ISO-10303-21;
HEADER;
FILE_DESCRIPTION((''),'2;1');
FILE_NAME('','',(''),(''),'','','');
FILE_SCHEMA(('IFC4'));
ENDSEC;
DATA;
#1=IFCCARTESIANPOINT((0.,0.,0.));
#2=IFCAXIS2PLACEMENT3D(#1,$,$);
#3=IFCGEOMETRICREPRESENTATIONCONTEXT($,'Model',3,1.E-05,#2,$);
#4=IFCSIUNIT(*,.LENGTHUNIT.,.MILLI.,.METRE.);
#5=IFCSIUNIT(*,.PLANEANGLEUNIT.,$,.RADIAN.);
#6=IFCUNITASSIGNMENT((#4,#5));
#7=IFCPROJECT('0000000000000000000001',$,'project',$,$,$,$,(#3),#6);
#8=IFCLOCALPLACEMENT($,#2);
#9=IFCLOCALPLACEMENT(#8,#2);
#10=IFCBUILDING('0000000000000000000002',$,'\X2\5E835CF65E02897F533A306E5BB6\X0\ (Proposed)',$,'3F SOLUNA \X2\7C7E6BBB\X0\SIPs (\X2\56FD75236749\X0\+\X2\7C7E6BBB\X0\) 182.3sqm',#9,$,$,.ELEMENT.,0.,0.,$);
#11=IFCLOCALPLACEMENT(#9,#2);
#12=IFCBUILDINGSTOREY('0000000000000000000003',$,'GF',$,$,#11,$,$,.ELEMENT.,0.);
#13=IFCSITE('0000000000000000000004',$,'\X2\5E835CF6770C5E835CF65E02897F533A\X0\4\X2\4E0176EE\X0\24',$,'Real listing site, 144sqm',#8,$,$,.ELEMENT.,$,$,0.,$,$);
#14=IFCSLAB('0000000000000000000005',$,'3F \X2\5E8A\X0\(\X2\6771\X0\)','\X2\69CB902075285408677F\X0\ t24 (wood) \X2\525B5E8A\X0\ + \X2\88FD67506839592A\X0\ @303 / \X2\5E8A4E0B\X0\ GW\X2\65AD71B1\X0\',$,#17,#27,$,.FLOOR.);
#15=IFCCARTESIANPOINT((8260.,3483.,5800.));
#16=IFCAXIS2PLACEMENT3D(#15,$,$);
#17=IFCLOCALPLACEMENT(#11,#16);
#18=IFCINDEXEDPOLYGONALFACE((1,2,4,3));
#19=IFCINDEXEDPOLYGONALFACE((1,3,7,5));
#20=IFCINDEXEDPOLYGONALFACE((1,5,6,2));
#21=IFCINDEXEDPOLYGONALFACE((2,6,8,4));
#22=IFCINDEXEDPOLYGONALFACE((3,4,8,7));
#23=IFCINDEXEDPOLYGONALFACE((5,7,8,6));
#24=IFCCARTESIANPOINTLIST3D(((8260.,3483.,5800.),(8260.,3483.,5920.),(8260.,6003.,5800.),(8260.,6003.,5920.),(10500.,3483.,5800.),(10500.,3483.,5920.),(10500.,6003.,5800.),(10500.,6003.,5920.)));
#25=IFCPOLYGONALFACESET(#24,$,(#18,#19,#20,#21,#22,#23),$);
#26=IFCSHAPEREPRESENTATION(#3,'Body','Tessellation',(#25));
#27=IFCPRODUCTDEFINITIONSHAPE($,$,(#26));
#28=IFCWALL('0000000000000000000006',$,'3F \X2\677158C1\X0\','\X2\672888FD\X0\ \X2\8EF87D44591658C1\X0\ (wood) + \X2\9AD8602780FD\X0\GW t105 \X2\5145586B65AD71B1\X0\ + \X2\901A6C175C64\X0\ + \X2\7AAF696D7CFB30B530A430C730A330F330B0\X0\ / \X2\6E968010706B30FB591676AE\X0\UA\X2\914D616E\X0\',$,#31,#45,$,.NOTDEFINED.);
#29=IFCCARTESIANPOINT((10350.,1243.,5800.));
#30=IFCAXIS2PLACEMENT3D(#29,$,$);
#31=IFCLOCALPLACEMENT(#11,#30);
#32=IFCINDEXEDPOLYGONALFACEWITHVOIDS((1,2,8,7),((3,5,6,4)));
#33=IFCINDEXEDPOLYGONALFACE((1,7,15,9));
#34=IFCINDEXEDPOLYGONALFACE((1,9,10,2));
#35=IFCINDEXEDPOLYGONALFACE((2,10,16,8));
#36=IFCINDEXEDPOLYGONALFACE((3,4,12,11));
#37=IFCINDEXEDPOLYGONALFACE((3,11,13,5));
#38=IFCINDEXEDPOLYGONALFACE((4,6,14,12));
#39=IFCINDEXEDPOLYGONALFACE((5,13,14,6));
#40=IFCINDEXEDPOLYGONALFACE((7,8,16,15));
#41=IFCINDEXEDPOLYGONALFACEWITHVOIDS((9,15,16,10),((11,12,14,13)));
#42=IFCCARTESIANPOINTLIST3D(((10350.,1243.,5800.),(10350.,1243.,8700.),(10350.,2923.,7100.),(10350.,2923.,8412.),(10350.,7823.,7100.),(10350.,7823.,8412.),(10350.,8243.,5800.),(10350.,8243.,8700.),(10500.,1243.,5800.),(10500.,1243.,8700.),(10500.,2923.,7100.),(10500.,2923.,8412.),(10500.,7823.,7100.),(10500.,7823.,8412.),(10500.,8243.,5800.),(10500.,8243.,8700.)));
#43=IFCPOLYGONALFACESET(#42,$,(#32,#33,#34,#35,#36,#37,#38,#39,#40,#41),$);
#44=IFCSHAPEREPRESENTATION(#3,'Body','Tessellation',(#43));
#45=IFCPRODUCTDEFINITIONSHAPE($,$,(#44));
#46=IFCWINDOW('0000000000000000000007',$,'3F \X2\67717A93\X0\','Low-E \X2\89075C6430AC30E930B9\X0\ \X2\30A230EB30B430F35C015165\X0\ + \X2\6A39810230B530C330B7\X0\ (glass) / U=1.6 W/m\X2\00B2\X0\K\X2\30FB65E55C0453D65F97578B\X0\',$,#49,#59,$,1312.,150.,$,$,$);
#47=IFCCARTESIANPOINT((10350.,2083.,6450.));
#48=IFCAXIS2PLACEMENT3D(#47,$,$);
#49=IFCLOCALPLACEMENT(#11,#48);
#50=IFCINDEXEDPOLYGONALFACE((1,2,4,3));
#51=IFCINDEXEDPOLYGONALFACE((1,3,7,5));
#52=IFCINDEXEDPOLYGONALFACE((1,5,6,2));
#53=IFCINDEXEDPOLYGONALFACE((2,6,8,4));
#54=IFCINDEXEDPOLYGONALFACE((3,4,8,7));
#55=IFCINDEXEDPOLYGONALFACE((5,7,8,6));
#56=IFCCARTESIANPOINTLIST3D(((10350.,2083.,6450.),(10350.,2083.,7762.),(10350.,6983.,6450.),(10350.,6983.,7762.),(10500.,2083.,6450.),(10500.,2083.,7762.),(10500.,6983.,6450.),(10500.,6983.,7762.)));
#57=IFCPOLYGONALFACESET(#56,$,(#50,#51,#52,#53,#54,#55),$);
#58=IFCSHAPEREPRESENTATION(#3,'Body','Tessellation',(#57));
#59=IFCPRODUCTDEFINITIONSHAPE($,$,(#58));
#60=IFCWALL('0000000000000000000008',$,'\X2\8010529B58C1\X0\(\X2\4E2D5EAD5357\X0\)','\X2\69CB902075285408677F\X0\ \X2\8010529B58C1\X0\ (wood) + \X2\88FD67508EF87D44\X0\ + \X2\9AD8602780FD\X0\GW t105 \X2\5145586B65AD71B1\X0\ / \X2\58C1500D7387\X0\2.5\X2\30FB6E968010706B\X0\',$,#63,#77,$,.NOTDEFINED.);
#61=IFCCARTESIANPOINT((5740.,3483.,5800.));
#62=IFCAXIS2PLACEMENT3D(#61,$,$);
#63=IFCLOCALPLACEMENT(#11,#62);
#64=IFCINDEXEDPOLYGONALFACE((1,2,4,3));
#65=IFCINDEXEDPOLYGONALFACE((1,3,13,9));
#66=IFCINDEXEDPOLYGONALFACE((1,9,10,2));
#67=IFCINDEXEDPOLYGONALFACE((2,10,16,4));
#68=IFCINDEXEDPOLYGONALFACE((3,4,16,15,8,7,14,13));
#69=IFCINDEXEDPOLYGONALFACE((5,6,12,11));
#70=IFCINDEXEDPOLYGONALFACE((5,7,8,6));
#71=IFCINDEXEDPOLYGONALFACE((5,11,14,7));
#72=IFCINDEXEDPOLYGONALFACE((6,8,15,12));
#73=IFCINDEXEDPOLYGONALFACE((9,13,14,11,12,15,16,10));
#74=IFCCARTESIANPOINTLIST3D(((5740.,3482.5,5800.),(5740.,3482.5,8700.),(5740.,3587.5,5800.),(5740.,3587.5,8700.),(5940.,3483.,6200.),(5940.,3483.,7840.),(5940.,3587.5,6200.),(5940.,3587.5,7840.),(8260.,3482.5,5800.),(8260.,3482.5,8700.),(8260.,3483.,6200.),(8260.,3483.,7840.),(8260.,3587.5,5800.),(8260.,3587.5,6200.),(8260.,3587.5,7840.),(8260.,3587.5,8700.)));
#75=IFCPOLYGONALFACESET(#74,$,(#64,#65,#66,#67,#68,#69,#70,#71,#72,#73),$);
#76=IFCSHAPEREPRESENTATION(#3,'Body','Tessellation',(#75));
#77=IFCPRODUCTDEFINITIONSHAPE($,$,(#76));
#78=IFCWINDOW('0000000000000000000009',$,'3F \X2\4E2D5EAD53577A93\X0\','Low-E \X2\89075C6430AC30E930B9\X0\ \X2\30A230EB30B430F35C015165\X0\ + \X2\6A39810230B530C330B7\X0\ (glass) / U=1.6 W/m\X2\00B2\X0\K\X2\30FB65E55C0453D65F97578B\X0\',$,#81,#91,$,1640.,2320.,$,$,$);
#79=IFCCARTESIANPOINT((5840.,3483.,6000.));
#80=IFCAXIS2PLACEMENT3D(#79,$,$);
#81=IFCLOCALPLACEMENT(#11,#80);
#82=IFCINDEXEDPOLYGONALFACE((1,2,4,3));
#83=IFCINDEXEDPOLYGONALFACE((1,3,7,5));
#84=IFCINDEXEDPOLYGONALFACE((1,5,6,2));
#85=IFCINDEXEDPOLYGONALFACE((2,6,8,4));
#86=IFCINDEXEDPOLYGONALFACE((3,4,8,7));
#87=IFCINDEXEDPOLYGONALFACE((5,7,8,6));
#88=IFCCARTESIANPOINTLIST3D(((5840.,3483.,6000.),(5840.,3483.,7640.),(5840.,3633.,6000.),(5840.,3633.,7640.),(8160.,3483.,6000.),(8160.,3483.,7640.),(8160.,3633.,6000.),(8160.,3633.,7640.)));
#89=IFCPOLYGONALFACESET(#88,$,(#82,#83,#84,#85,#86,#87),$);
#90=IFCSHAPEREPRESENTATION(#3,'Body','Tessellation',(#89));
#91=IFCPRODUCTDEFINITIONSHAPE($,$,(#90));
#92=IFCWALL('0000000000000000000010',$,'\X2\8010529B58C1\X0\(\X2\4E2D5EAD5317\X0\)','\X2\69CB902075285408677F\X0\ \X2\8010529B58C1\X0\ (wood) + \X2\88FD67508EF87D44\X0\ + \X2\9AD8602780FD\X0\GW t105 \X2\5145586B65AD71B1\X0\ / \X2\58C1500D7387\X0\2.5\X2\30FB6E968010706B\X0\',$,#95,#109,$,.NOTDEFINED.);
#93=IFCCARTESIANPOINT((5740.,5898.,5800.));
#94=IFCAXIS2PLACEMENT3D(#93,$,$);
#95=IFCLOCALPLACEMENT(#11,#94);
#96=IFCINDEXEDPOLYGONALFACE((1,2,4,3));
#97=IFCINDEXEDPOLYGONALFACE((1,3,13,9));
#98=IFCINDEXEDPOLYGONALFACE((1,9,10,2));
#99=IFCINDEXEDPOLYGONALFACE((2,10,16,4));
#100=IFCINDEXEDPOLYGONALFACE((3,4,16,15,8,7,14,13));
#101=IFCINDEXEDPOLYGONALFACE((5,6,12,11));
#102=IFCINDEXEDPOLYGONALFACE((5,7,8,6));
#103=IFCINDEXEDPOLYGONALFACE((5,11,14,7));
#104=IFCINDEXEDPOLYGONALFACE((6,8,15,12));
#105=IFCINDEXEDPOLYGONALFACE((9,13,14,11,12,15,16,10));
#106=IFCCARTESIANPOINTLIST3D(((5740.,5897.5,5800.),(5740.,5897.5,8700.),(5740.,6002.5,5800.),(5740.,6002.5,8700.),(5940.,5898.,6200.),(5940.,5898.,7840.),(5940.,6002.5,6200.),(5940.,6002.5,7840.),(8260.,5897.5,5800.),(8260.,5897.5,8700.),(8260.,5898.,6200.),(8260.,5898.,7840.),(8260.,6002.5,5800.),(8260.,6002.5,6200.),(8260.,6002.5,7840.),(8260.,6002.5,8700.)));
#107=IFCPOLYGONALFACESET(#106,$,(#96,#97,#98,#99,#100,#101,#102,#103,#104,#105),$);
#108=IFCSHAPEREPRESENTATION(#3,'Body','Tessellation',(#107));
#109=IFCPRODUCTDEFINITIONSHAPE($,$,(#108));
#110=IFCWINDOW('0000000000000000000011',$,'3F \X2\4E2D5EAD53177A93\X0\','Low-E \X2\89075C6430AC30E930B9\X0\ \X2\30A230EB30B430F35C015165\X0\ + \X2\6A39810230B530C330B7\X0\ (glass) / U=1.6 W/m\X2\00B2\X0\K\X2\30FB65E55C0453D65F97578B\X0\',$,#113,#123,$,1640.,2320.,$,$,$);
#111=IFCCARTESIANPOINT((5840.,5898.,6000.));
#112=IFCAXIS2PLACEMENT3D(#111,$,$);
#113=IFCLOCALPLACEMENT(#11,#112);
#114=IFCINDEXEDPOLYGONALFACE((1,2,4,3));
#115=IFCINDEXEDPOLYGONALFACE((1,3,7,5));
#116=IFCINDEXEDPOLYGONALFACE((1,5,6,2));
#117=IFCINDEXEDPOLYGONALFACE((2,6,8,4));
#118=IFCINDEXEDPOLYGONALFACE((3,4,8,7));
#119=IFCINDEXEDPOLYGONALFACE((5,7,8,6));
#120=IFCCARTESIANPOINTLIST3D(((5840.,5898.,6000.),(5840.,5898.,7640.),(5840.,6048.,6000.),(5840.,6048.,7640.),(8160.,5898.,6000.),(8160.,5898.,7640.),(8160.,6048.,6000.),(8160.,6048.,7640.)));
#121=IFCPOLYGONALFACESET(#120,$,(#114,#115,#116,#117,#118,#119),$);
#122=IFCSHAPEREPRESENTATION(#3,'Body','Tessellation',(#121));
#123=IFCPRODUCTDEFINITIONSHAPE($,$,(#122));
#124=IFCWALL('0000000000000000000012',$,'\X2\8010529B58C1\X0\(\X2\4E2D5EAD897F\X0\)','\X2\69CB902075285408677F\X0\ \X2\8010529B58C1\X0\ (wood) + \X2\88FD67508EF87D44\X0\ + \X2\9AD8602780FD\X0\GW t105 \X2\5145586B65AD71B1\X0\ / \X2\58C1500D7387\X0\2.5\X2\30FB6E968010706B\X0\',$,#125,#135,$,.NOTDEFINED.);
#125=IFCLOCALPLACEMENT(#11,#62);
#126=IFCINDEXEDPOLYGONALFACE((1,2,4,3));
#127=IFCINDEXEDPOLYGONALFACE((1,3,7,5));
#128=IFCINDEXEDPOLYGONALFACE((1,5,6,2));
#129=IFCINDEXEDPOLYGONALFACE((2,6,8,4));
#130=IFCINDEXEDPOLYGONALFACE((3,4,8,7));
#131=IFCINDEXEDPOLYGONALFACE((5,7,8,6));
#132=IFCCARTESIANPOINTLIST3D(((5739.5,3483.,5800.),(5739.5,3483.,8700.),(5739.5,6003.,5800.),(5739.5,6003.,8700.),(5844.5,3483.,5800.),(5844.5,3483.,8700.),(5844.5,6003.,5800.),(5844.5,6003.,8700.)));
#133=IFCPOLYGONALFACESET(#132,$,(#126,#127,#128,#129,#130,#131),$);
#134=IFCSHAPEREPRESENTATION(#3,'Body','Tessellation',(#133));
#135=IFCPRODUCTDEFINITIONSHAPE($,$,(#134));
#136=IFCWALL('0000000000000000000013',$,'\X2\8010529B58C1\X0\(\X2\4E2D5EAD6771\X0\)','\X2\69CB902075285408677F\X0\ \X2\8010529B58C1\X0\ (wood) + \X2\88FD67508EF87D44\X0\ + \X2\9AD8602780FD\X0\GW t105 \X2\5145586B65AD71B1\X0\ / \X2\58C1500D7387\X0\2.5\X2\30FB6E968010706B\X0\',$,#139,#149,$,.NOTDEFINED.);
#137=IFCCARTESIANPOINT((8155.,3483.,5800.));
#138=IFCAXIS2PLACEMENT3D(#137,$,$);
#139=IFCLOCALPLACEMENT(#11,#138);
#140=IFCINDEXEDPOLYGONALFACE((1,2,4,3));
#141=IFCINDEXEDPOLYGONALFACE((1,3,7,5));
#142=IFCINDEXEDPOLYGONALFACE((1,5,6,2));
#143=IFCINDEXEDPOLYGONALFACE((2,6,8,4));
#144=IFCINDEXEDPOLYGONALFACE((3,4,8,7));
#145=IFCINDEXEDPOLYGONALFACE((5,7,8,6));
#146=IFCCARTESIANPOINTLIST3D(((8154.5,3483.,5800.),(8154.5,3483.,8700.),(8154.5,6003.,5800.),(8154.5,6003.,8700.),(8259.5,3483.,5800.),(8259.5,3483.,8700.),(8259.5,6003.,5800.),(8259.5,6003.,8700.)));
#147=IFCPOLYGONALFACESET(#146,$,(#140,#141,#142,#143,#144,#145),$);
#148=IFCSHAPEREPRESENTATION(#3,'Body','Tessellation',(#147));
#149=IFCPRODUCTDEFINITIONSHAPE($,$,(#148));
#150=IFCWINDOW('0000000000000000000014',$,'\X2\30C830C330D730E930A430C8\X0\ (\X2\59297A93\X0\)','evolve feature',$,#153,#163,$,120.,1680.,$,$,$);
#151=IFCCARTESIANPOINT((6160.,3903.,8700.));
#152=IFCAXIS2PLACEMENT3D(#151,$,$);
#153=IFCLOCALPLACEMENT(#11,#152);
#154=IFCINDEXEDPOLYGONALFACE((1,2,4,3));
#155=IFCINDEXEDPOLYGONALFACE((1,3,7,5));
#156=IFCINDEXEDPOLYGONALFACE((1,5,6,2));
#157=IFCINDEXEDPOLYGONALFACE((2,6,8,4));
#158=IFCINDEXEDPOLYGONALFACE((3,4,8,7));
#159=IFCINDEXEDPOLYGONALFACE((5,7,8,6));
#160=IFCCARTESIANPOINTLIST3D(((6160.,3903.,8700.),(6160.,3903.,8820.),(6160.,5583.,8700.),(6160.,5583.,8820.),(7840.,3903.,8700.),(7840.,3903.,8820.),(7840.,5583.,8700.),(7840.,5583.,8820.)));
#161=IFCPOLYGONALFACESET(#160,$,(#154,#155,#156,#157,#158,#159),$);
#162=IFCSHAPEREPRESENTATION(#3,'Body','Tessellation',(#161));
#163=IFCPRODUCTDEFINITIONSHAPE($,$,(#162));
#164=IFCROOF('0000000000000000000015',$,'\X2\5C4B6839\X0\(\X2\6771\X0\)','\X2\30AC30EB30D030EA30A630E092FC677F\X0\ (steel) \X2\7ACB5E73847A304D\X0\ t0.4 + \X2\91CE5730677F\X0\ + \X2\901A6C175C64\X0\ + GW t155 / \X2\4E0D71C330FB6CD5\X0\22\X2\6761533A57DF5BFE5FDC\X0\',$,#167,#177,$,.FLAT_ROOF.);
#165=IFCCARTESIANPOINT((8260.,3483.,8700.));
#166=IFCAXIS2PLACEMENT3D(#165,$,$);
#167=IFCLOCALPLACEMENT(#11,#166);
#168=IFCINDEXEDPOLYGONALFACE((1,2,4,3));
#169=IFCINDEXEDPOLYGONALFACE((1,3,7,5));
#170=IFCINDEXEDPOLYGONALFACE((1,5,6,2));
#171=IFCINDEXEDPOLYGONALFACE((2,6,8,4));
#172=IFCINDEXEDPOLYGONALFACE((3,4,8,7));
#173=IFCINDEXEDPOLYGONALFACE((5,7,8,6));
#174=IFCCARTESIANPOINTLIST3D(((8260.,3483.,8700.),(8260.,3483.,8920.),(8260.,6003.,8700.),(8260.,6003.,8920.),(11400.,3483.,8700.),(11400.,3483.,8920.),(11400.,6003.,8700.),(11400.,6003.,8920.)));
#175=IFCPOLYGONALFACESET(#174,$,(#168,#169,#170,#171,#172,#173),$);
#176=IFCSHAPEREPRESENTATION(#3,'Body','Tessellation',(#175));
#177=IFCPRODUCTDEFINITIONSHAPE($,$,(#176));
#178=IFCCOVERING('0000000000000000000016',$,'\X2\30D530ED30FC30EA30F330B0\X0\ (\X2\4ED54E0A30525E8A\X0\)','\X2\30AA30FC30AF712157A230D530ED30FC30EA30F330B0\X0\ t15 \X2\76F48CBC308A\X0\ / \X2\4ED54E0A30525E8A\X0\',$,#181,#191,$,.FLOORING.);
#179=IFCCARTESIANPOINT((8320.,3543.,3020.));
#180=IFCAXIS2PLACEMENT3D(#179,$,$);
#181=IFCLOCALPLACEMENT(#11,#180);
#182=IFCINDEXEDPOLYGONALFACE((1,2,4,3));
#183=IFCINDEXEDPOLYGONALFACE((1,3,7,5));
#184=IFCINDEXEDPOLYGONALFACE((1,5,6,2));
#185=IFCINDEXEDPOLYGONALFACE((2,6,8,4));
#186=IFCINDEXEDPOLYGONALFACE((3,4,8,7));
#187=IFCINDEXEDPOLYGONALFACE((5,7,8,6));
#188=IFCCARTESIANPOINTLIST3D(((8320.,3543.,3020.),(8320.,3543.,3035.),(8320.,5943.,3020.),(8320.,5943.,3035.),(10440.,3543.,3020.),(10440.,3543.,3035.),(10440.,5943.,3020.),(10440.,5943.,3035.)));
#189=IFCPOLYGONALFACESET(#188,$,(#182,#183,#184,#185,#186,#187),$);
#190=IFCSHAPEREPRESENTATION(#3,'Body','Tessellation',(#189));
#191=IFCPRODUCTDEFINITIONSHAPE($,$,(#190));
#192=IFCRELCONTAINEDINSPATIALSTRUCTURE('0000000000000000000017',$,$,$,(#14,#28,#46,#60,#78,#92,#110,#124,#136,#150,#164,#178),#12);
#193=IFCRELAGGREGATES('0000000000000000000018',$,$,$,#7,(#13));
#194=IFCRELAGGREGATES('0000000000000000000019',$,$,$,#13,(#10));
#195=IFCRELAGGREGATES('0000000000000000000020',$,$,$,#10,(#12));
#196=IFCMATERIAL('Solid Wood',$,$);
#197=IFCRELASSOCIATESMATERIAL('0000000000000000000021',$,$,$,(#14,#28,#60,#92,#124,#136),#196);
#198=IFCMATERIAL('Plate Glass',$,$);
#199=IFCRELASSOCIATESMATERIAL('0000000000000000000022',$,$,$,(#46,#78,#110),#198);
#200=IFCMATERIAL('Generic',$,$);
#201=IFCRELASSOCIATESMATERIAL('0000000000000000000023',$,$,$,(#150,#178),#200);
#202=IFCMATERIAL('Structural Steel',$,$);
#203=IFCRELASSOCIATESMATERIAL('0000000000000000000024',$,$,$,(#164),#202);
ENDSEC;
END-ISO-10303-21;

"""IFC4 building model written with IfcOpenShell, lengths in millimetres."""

from ifc_helpers import new_model, si_unit, frame, frame_2d, origin, place, context, project, spatial, rectangle, extrude, material, element, fill, save


model = new_model("IFC4")

# Units and contexts
model_context = context("Model", 3, precision=1e-05, world=origin())
ifc_project = project(units=[si_unit("LENGTHUNIT", "METRE", prefix="MILLI"), si_unit("PLANEANGLEUNIT", "RADIAN")], contexts=[model_context])

# Site, building, storey
site_placement = place(None, origin())
site = spatial("IfcSite", under=ifc_project, at=site_placement, Name="広島県広島市西区4丁目24", ObjectType="Real listing site, 144sqm", CompositionType="ELEMENT", RefElevation=0.0)
building_placement = place(site_placement, origin())
building = spatial("IfcBuilding", under=site, at=building_placement, Name="広島市西区の家 (Proposed)", ObjectType="3F SOLUNA 籾殻SIPs (国産杉+籾殻) 182.3sqm", CompositionType="ELEMENT", ElevationOfRefHeight=0.0, ElevationOfTerrain=0.0)
storey_placement = place(building_placement, origin())
storey = spatial("IfcBuildingStorey", under=building, at=storey_placement, Name="GF", CompositionType="ELEMENT", Elevation=0.0)

# Slab
ifc_material_1 = material(Name="Solid Wood")
slab_placement = place(storey_placement, frame((8260.0, 3483.0, 5800.0)))
element("IfcSlab", 1, at=slab_placement, inside=storey, material=ifc_material_1, Name="3F 床(東)", Description="構造用合板 t24 (wood) 剛床 + 製材根太 @303 / 床下 GW断熱", PredefinedType="FLOOR", context=model_context, shape_type="SweptSolid", body=[
    extrude(rectangle(XDim=2240.0, YDim=2520.0, at=frame_2d((1120.0, 1260.0))), frame((8260.0, 3483.0, 5800.0)), (0.0, 0.0, 1.0), 120.0),
])

# Walls, openings, windows
wall_1_placement = place(storey_placement, frame((10350.0, 1243.0, 5800.0)))
wall_1 = element("IfcWall", 2, at=wall_1_placement, inside=storey, material=ifc_material_1, Name="3F 東壁", Description="木製 軸組外壁 (wood) + 高性能GW t105 充填断熱 + 通気層 + 窯業系サイディング / 準耐火・外皮UA配慮", PredefinedType="NOTDEFINED", context=model_context, shape_type="SweptSolid", body=[
    extrude(rectangle(XDim=150.0, YDim=7000.0, at=frame_2d((75.0, 3500.0))), frame((10350.0, 1243.0, 5800.0)), (0.0, 0.0, 1.0), 2900.0),
])
opening_1_placement = place(storey_placement, frame((10350.0, 2083.0, 6450.0)))
opening_1 = element("IfcOpeningElement", 3, at=opening_1_placement, cuts=wall_1, PredefinedType="NOTDEFINED", context=model_context, shape_type="SweptSolid", body=[
    extrude(rectangle(XDim=150.0, YDim=4900.0, at=frame_2d((75.0, 2450.0))), frame((10350.0, 2083.0, 6450.0)), (0.0, 0.0, 1.0), 1312.0),
])
ifc_material_2 = material(Name="Plate Glass")
window_1_placement = place(storey_placement, frame((10350.0, 2083.0, 6450.0)))
window_1 = element("IfcWindow", 4, at=window_1_placement, inside=storey, material=ifc_material_2, Name="3F 東窓", Description="Low-E 複層ガラス アルゴン封入 + 樹脂サッシ (glass) / U=1.6 W/m²K・日射取得型", OverallHeight=1312.0, OverallWidth=150.0, context=model_context, shape_type="SweptSolid", body=[
    extrude(rectangle(XDim=150.0, YDim=4900.0, at=frame_2d((75.0, 2450.0))), frame((10350.0, 2083.0, 6450.0)), (0.0, 0.0, 1.0), 1312.0),
])
fill(opening_1, window_1)
wall_2_placement = place(storey_placement, frame((5740.0, 3483.0, 5800.0)))
wall_2 = element("IfcWall", 5, at=wall_2_placement, inside=storey, material=ifc_material_1, Name="耐力壁(中庭南)", Description="構造用合板 耐力壁 (wood) + 製材軸組 + 高性能GW t105 充填断熱 / 壁倍率2.5・準耐火", PredefinedType="NOTDEFINED", context=model_context, shape_type="SweptSolid", body=[
    extrude(rectangle(XDim=2520.0, YDim=105.0, at=frame_2d((1260.0, 52.0))), frame((5740.0, 3483.0, 5800.0)), (0.0, 0.0, 1.0), 2900.0),
])
opening_2_placement = place(storey_placement, frame((5840.0, 3483.0, 6000.0)))
opening_2 = element("IfcOpeningElement", 6, at=opening_2_placement, cuts=wall_2, PredefinedType="NOTDEFINED", context=model_context, shape_type="SweptSolid", body=[
    extrude(rectangle(XDim=2320.0, YDim=150.0, at=frame_2d((1160.0, 75.0))), frame((5840.0, 3483.0, 6000.0)), (0.0, 0.0, 1.0), 1640.0),
])
window_2_placement = place(storey_placement, frame((5840.0, 3483.0, 6000.0)))
window_2 = element("IfcWindow", 7, at=window_2_placement, inside=storey, material=ifc_material_2, Name="3F 中庭南窓", Description="Low-E 複層ガラス アルゴン封入 + 樹脂サッシ (glass) / U=1.6 W/m²K・日射取得型", OverallHeight=1640.0, OverallWidth=2320.0, context=model_context, shape_type="SweptSolid", body=[
    extrude(rectangle(XDim=2320.0, YDim=150.0, at=frame_2d((1160.0, 75.0))), frame((5840.0, 3483.0, 6000.0)), (0.0, 0.0, 1.0), 1640.0),
])
fill(opening_2, window_2)
wall_3_placement = place(storey_placement, frame((5740.0, 5898.0, 5800.0)))
wall_3 = element("IfcWall", 8, at=wall_3_placement, inside=storey, material=ifc_material_1, Name="耐力壁(中庭北)", Description="構造用合板 耐力壁 (wood) + 製材軸組 + 高性能GW t105 充填断熱 / 壁倍率2.5・準耐火", PredefinedType="NOTDEFINED", context=model_context, shape_type="SweptSolid", body=[
    extrude(rectangle(XDim=2520.0, YDim=105.0, at=frame_2d((1260.0, 52.0))), frame((5740.0, 5898.0, 5800.0)), (0.0, 0.0, 1.0), 2900.0),
])
opening_3_placement = place(storey_placement, frame((5840.0, 5898.0, 6000.0)))
opening_3 = element("IfcOpeningElement", 9, at=opening_3_placement, cuts=wall_3, PredefinedType="NOTDEFINED", context=model_context, shape_type="SweptSolid", body=[
    extrude(rectangle(XDim=2320.0, YDim=150.0, at=frame_2d((1160.0, 75.0))), frame((5840.0, 5898.0, 6000.0)), (0.0, 0.0, 1.0), 1640.0),
])
window_3_placement = place(storey_placement, frame((5840.0, 5898.0, 6000.0)))
window_3 = element("IfcWindow", 10, at=window_3_placement, inside=storey, material=ifc_material_2, Name="3F 中庭北窓", Description="Low-E 複層ガラス アルゴン封入 + 樹脂サッシ (glass) / U=1.6 W/m²K・日射取得型", OverallHeight=1640.0, OverallWidth=2320.0, context=model_context, shape_type="SweptSolid", body=[
    extrude(rectangle(XDim=2320.0, YDim=150.0, at=frame_2d((1160.0, 75.0))), frame((5840.0, 5898.0, 6000.0)), (0.0, 0.0, 1.0), 1640.0),
])
fill(opening_3, window_3)

# Walls
wall_4_placement = place(storey_placement, frame((5740.0, 3483.0, 5800.0)))
element("IfcWall", 11, at=wall_4_placement, inside=storey, material=ifc_material_1, Name="耐力壁(中庭西)", Description="構造用合板 耐力壁 (wood) + 製材軸組 + 高性能GW t105 充填断熱 / 壁倍率2.5・準耐火", PredefinedType="NOTDEFINED", context=model_context, shape_type="SweptSolid", body=[
    extrude(rectangle(XDim=105.0, YDim=2520.0, at=frame_2d((52.0, 1260.0))), frame((5740.0, 3483.0, 5800.0)), (0.0, 0.0, 1.0), 2900.0),
])
wall_5_placement = place(storey_placement, frame((8155.0, 3483.0, 5800.0)))
element("IfcWall", 12, at=wall_5_placement, inside=storey, material=ifc_material_1, Name="耐力壁(中庭東)", Description="構造用合板 耐力壁 (wood) + 製材軸組 + 高性能GW t105 充填断熱 / 壁倍率2.5・準耐火", PredefinedType="NOTDEFINED", context=model_context, shape_type="SweptSolid", body=[
    extrude(rectangle(XDim=105.0, YDim=2520.0, at=frame_2d((52.0, 1260.0))), frame((8155.0, 3483.0, 5800.0)), (0.0, 0.0, 1.0), 2900.0),
])

# Window
ifc_material_3 = material(Name="Generic")
window_4_placement = place(storey_placement, frame((6160.0, 3903.0, 8700.0)))
element("IfcWindow", 13, at=window_4_placement, inside=storey, material=ifc_material_3, Name="トップライト (天窓)", Description="evolve feature", OverallHeight=120.0, OverallWidth=1680.0, context=model_context, shape_type="SweptSolid", body=[
    extrude(rectangle(XDim=1680.0, YDim=1680.0, at=frame_2d((840.0, 840.0))), frame((6160.0, 3903.0, 8700.0)), (0.0, 0.0, 1.0), 120.0),
])

# Roof
ifc_material_4 = material(Name="Structural Steel")
for number, where, name in (
    (14, (8260.0, 3483.0, 8700.0), "屋根(東)"),
):
    element("IfcRoof", number, at=place(storey_placement, frame(where)), inside=storey, material=ifc_material_4, Name=name, Description="ガルバリウム鋼板 (steel) 立平葺き t0.4 + 野地板 + 通気層 + GW t155 / 不燃・法22条区域対応", PredefinedType="FLAT_ROOF", context=model_context, shape_type="SweptSolid", body=[
        extrude(rectangle(XDim=3140.0, YDim=2520.0, at=frame_2d((1570.0, 1260.0))), frame((8260.0, 3483.0, 8700.0)), (0.0, 0.0, 1.0), 220.0),
    ])

# Covering
covering_1_placement = place(storey_placement, frame((8320.0, 3543.0, 3020.0)))
element("IfcCovering", 15, at=covering_1_placement, inside=storey, material=ifc_material_3, Name="フローリング (仕上げ床)", Description="オーク無垢フローリング t15 直貼り / 仕上げ床", PredefinedType="FLOORING", context=model_context, shape_type="SweptSolid", body=[
    extrude(rectangle(XDim=2120.0, YDim=2400.0, at=frame_2d((1060.0, 1200.0))), frame((8320.0, 3543.0, 3020.0)), (0.0, 0.0, 1.0), 15.0),
])

save(model, "model.ifc")
